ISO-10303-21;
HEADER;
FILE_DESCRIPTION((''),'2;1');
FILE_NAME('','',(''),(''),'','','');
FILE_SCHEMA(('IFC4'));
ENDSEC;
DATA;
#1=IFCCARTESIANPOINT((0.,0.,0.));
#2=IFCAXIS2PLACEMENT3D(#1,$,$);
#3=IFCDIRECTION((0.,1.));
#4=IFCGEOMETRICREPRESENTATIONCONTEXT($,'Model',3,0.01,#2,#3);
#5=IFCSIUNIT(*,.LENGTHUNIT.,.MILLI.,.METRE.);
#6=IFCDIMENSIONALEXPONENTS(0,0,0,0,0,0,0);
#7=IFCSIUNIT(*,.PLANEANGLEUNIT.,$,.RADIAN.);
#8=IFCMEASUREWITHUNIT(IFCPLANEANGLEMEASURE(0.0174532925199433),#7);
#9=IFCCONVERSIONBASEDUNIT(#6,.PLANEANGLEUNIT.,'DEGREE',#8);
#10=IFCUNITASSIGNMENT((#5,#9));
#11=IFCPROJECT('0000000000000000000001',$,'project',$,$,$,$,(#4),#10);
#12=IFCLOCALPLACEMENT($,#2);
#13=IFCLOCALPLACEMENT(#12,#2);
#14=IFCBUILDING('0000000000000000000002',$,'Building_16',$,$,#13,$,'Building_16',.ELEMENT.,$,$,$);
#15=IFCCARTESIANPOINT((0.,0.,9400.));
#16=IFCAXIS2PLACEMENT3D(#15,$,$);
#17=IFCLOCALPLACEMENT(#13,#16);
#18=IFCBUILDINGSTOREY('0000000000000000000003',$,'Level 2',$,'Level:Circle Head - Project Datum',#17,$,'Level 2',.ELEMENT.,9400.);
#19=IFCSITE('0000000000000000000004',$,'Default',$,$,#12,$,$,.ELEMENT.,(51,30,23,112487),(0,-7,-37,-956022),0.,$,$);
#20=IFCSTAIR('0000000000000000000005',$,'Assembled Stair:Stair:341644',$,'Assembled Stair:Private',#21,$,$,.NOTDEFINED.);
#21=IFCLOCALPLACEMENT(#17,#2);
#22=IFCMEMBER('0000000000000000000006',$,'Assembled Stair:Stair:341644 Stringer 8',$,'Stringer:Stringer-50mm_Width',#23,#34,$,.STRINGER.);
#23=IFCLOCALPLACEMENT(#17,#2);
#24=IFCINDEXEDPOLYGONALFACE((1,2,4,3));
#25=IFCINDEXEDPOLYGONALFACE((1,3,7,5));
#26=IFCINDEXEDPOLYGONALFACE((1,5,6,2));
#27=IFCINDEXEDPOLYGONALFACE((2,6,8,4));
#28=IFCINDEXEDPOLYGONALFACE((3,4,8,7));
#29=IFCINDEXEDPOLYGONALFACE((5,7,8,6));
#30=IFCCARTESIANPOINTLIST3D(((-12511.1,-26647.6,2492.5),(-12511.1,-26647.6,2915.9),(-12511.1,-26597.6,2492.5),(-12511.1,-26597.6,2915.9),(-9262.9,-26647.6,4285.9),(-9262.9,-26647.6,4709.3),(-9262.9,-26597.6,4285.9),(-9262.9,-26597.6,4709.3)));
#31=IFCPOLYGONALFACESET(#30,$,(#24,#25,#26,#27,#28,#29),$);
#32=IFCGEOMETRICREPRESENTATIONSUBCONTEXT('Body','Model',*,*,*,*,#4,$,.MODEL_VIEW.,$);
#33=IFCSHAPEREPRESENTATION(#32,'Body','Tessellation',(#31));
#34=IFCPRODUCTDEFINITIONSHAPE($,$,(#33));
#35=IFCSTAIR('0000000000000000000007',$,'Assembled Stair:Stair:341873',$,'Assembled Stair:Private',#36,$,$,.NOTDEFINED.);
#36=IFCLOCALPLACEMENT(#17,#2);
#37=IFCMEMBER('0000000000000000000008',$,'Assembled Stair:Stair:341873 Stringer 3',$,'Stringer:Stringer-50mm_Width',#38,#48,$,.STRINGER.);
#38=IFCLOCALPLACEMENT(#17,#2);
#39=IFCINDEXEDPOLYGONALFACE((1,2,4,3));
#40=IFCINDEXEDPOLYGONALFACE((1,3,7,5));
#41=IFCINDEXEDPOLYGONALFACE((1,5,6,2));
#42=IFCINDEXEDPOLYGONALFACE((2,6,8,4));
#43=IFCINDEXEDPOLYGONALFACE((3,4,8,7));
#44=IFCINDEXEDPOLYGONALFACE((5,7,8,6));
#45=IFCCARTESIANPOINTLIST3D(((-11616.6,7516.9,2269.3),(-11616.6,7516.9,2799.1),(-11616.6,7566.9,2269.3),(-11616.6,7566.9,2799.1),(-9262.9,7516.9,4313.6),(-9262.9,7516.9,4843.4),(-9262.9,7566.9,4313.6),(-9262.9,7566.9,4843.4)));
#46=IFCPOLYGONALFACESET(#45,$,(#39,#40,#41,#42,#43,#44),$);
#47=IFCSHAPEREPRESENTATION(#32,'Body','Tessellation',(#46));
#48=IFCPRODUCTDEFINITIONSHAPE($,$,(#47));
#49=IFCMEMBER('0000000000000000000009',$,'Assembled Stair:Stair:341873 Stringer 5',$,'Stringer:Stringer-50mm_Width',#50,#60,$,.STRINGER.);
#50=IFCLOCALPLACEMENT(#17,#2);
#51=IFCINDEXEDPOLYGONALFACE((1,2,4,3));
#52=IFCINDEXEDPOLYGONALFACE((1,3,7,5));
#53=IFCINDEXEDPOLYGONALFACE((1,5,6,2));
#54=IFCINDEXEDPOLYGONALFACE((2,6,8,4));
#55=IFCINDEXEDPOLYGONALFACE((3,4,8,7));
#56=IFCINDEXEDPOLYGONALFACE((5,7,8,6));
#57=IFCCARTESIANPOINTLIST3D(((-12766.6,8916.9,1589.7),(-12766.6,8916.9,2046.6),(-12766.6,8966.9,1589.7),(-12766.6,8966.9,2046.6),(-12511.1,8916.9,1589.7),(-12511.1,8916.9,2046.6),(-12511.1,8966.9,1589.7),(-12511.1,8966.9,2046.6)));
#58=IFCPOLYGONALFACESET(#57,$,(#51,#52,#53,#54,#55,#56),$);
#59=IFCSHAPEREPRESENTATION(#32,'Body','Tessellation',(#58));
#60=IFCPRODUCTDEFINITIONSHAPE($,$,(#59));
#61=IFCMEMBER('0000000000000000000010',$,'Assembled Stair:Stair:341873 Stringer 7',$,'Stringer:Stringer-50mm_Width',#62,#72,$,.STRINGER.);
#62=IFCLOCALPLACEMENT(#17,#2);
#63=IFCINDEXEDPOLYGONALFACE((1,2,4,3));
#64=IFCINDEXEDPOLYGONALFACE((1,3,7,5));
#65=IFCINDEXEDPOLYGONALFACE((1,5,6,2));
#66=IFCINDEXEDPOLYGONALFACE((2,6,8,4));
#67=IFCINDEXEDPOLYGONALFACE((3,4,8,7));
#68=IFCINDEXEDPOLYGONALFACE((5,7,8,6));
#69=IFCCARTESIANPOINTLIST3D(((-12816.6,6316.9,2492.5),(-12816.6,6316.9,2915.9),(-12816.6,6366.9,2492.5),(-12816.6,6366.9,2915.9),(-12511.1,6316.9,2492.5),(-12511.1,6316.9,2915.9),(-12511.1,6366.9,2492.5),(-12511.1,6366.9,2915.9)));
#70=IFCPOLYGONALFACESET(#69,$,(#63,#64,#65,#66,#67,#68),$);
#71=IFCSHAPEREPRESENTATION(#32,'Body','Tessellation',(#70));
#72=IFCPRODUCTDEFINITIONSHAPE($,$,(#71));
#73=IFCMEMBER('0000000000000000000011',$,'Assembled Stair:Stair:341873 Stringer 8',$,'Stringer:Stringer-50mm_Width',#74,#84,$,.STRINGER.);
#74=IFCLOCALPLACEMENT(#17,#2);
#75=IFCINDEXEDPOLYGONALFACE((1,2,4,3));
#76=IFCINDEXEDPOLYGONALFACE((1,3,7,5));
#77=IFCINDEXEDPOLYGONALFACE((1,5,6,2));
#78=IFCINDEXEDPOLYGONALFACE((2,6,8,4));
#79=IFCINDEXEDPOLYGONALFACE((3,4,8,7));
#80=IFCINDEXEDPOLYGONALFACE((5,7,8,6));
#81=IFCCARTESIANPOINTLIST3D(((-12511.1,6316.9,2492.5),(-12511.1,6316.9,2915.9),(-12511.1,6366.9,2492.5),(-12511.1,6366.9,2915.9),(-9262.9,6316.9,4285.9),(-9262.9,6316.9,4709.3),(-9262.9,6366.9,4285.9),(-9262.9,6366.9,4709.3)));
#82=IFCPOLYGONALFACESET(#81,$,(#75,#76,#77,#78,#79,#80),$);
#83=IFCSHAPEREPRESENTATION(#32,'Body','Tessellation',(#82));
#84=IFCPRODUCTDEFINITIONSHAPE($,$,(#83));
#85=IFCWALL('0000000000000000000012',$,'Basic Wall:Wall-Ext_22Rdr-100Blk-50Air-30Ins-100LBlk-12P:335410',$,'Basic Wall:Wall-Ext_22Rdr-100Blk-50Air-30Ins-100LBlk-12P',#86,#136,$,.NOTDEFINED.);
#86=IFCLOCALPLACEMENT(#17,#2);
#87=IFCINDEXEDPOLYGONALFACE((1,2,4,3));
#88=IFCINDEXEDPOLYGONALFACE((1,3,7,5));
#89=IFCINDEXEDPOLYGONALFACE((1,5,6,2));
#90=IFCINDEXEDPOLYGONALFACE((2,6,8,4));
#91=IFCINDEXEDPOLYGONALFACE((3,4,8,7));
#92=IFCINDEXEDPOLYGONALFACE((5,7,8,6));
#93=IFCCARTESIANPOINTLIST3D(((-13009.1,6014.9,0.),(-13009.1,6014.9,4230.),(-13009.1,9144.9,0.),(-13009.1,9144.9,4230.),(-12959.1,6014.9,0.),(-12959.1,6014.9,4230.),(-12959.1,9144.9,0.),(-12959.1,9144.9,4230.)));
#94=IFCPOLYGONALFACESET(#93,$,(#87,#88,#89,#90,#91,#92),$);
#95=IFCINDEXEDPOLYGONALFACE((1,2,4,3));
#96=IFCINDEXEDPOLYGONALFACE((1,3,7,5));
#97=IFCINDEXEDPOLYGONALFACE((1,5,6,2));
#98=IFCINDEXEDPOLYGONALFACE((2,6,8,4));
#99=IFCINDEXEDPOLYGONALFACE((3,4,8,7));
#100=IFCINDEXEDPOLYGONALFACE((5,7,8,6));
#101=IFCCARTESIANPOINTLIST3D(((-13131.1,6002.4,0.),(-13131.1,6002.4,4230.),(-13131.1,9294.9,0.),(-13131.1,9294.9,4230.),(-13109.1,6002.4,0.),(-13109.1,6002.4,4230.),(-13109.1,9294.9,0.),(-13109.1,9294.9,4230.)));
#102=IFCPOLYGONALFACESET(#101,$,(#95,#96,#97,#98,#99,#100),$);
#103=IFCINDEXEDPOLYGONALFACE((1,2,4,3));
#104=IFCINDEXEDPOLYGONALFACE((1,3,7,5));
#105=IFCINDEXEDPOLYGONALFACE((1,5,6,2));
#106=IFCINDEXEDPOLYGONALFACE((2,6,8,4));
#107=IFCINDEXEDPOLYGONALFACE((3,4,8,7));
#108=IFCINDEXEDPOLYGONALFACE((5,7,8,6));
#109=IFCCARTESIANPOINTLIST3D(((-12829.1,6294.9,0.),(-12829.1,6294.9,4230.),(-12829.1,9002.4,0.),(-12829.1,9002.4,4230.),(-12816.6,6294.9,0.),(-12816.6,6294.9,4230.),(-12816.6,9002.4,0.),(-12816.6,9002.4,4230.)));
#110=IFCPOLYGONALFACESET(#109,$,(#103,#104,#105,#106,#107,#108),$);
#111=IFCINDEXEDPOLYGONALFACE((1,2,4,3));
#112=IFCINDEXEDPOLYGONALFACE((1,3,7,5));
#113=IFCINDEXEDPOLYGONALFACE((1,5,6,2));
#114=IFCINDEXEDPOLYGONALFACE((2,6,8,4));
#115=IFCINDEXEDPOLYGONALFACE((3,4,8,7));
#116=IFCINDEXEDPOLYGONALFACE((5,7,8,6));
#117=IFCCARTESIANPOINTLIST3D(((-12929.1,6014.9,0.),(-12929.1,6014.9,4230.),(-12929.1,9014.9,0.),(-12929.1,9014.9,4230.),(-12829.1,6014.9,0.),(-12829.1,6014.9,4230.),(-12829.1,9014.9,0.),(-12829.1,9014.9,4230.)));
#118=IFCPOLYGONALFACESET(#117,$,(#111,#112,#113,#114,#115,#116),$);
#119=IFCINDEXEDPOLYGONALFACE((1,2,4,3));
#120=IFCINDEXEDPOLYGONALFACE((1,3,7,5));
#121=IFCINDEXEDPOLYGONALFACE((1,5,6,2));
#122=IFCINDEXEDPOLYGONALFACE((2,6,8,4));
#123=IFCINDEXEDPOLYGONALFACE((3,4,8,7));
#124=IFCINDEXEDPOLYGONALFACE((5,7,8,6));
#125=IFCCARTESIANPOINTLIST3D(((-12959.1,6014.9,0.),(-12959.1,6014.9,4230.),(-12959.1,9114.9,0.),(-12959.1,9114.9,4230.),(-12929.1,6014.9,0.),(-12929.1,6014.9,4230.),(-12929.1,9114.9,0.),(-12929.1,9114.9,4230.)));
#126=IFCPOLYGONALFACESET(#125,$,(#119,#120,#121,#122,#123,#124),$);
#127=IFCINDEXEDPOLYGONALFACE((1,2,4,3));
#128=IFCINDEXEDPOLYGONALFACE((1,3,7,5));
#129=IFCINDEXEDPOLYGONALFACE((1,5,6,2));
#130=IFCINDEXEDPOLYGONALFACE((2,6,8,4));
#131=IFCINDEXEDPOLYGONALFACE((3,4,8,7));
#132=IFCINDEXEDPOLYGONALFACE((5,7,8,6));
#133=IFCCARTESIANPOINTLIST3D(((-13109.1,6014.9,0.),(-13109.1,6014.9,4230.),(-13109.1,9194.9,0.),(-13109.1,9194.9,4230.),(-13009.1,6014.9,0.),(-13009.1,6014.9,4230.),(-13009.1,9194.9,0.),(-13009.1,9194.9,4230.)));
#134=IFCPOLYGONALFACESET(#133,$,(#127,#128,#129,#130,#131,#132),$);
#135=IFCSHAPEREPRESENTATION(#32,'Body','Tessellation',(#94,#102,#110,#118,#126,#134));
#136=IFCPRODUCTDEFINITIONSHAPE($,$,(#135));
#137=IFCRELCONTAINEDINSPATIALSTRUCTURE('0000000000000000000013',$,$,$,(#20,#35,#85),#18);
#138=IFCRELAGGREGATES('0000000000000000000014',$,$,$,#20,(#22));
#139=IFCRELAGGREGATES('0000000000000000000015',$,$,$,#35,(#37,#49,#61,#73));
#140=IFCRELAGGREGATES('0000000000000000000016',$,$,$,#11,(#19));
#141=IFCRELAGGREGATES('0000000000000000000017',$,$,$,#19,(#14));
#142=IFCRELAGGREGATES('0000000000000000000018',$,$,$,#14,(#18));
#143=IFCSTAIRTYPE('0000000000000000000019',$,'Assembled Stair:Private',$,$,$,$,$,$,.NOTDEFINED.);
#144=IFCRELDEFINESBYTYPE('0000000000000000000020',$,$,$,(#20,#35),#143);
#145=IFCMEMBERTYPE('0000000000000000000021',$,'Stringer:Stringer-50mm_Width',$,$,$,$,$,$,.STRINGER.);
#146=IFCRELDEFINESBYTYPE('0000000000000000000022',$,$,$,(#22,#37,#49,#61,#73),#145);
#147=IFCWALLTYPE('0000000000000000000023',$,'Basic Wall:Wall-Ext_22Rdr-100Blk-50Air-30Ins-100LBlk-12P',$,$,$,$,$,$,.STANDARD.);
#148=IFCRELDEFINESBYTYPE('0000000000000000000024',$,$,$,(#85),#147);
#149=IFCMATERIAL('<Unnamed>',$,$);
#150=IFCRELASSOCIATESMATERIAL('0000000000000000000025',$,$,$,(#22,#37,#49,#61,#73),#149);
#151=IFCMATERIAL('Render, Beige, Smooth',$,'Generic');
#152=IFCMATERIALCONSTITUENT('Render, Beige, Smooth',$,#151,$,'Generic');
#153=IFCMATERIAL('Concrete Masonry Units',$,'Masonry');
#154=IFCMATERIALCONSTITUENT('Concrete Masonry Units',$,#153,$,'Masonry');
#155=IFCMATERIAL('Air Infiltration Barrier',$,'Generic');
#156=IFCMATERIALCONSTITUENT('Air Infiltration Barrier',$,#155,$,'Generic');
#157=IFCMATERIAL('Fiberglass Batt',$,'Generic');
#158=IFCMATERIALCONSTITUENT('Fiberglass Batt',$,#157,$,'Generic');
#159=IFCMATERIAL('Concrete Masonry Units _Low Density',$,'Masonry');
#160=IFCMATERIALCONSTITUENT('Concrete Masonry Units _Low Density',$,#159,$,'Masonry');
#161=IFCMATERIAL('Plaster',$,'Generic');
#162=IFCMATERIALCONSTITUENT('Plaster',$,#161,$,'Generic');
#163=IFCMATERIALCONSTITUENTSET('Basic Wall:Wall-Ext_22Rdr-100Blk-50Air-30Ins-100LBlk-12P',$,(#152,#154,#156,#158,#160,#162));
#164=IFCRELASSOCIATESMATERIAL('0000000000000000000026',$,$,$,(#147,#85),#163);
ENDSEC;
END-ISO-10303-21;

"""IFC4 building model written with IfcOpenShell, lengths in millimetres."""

from ifc_helpers import new_model, entity, si_unit, converted_unit, direction, frame, origin, place, context, subcontext, project, spatial, indexed_curve, outline, extrude, material, constituent, constituent_set, type_object, element, aggregate, save


model = new_model("IFC4")

# Units and contexts
model_context = context("Model", 3, precision=0.01, world=origin(), true_north=direction((0.0, 1.0)))
body_context = subcontext(model_context, "Body", "Model", "MODEL_VIEW")
ifc_project = project(units=[si_unit("LENGTHUNIT", "METRE", prefix="MILLI"), converted_unit("PLANEANGLEUNIT", "DEGREE", entity("IfcPlaneAngleMeasure", 0.0174532925199433), si_unit("PLANEANGLEUNIT", "RADIAN"), dimensions=[0, 0, 0, 0, 0, 0, 0])], contexts=[model_context])

# Site, building, storey
site_placement = place(None, origin())
site = spatial("IfcSite", under=ifc_project, at=site_placement, Name="Default", CompositionType="ELEMENT", RefLatitude=(51, 30, 23, 112487), RefLongitude=(0, -7, -37, -956022), RefElevation=0.0)
building_placement = place(site_placement, origin())
building = spatial("IfcBuilding", under=site, at=building_placement, Name="Building_16", LongName="Building_16", CompositionType="ELEMENT")
storey_placement = place(building_placement, frame((0.0, 0.0, 9400.0)))
storey = spatial("IfcBuildingStorey", under=building, at=storey_placement, Name="Level 2", ObjectType="Level:Circle Head - Project Datum", LongName="Level 2", CompositionType="ELEMENT", Elevation=9400.0)

# Stair, member
stair_type = type_object("IfcStairType", Name="Assembled Stair:Private", PredefinedType="NOTDEFINED")
stair_1_placement = place(storey_placement, origin())
stair_1 = element("IfcStair", 1, at=stair_1_placement, inside=storey, type_object=stair_type, Name="Assembled Stair:Stair:341644", ObjectType="Assembled Stair:Private", PredefinedType="NOTDEFINED")
ifc_material_1 = material(Name="<Unnamed>")
member_type = type_object("IfcMemberType", Name="Stringer:Stringer-50mm_Width", PredefinedType="STRINGER")
member_1_placement = place(stair_1_placement, origin())
member_1 = element("IfcMember", 2, at=member_1_placement, type_object=member_type, material=ifc_material_1, Name="Assembled Stair:Stair:341644 Stringer 8", ObjectType="Stringer:Stringer-50mm_Width", PredefinedType="STRINGER", context=body_context, shape_type="SweptSolid", body=[
    extrude(outline(indexed_curve([(-1752.9, -185.3), (1957.5, -185.3), (1752.9, 185.3), (-1957.5, 185.3), (-1752.9, -185.3)], self_intersect=False)), frame((-10887.0, -26647.6, 3600.9), z_axis=(0.0, 1.0, 0.0), x_axis=(0.875434, 0.0, 0.483338)), (0.0, 0.0, 1.0), 50.0),
])
aggregate(stair_1, [member_1])

# Stair, members
stair_2_placement = place(storey_placement, origin())
stair_2 = element("IfcStair", 3, at=stair_2_placement, inside=storey, type_object=stair_type, Name="Assembled Stair:Stair:341873", ObjectType="Assembled Stair:Private", PredefinedType="NOTDEFINED")
member_2_placement = place(stair_2_placement, origin())
member_2 = element("IfcMember", 4, at=member_2_placement, type_object=member_type, material=ifc_material_1, Name="Assembled Stair:Stair:341873 Stringer 3", ObjectType="Stringer:Stringer-50mm_Width", PredefinedType="STRINGER", context=body_context, shape_type="SweptSolid", body=[
    extrude(outline(indexed_curve([(-1385.1, -200.0), (1732.5, -200.0), (1385.1, 200.0), (-1732.5, 200.0), (-1385.1, -200.0)], self_intersect=False)), frame((-10439.8, 7516.9, 3556.4), z_axis=(0.0, 1.0, 0.0), x_axis=(0.754989, 0.0, 0.655738)), (0.0, 0.0, 1.0), 50.0),
])
member_3_placement = place(stair_2_placement, origin())
member_3 = element("IfcMember", 5, at=member_3_placement, type_object=member_type, material=ifc_material_1, Name="Assembled Stair:Stair:341873 Stringer 5", ObjectType="Stringer:Stringer-50mm_Width", PredefinedType="STRINGER", context=body_context, shape_type="SweptSolid", body=[
    extrude(outline(indexed_curve([(-127.7, -25.0), (127.7, -25.0), (127.7, 25.0), (-127.7, 25.0), (-127.7, -25.0)], self_intersect=False)), frame((-12638.9, 8941.9, 1589.7), z_axis=(0.0, 0.0, 1.0), x_axis=(-1.0, 0.0, 0.0)), (0.0, 0.0, 1.0), 456.9),
])
member_4_placement = place(stair_2_placement, origin())
member_4 = element("IfcMember", 6, at=member_4_placement, type_object=member_type, material=ifc_material_1, Name="Assembled Stair:Stair:341873 Stringer 7", ObjectType="Stringer:Stringer-50mm_Width", PredefinedType="STRINGER", context=body_context, shape_type="SweptSolid", body=[
    extrude(outline(indexed_curve([(-152.7, -25.0), (152.7, -25.0), (152.7, 25.0), (-152.7, 25.0), (-152.7, -25.0)], self_intersect=False)), frame((-12663.9, 6341.9, 2492.5)), (0.0, 0.0, 1.0), 423.4),
])
member_5_placement = place(stair_2_placement, origin())
member_5 = element("IfcMember", 7, at=member_5_placement, type_object=member_type, material=ifc_material_1, Name="Assembled Stair:Stair:341873 Stringer 8", ObjectType="Stringer:Stringer-50mm_Width", PredefinedType="STRINGER", context=body_context, shape_type="SweptSolid", body=[
    extrude(outline(indexed_curve([(-1752.9, -185.3), (1957.5, -185.3), (1752.9, 185.3), (-1957.5, 185.3), (-1752.9, -185.3)], self_intersect=False)), frame((-10887.0, 6316.9, 3600.9), z_axis=(0.0, 1.0, 0.0), x_axis=(0.875434, 0.0, 0.483338)), (0.0, 0.0, 1.0), 50.0),
])
aggregate(stair_2, [member_2, member_3, member_4, member_5])

# Shared definitions
ifc_material_2 = material(Name="Render, Beige, Smooth", Category="Generic")
ifc_constituent_1 = constituent(ifc_material_2, Name="Render, Beige, Smooth", Category="Generic")
ifc_material_3 = material(Name="Concrete Masonry Units", Category="Masonry")
ifc_constituent_2 = constituent(ifc_material_3, Name="Concrete Masonry Units", Category="Masonry")
ifc_material_4 = material(Name="Air Infiltration Barrier", Category="Generic")
ifc_constituent_3 = constituent(ifc_material_4, Name="Air Infiltration Barrier", Category="Generic")
ifc_material_5 = material(Name="Fiberglass Batt", Category="Generic")
ifc_constituent_4 = constituent(ifc_material_5, Name="Fiberglass Batt", Category="Generic")
ifc_material_6 = material(Name="Concrete Masonry Units _Low Density", Category="Masonry")
ifc_constituent_5 = constituent(ifc_material_6, Name="Concrete Masonry Units _Low Density", Category="Masonry")
ifc_material_7 = material(Name="Plaster", Category="Generic")
ifc_constituent_6 = constituent(ifc_material_7, Name="Plaster", Category="Generic")
ifc_constituent_set_1 = constituent_set(constituents=[ifc_constituent_1, ifc_constituent_2, ifc_constituent_3, ifc_constituent_4, ifc_constituent_5, ifc_constituent_6], Name="Basic Wall:Wall-Ext_22Rdr-100Blk-50Air-30Ins-100LBlk-12P")
wall_type_1 = type_object("IfcWallType", Name="Basic Wall:Wall-Ext_22Rdr-100Blk-50Air-30Ins-100LBlk-12P", PredefinedType="STANDARD", material=ifc_constituent_set_1)

# Wall
wall_1_placement = place(storey_placement, frame((-12973.9, 6002.4, 0.0), z_axis=(0.0, 0.0, 1.0), x_axis=(0.0, 1.0, 0.0)))
element("IfcWall", 8, at=wall_1_placement, inside=storey, type_object=wall_type_1, material=ifc_constituent_set_1, Name="Basic Wall:Wall-Ext_22Rdr-100Blk-50Air-30Ins-100LBlk-12P:335410", ObjectType="Basic Wall:Wall-Ext_22Rdr-100Blk-50Air-30Ins-100LBlk-12P", PredefinedType="NOTDEFINED", context=body_context, shape_type="SweptSolid", body=[
    extrude(outline(indexed_curve([(-2115.0, -1565.0), (2115.0, -1565.0), (2115.0, 1565.0), (-2115.0, 1565.0), (-2115.0, -1565.0)], self_intersect=False)), frame((1577.5, 35.3, 2115.0), z_axis=(0.0, -1.0, 0.0), x_axis=(0.0, 0.0, 1.0)), (0.0, 0.0, 1.0), 50.0),
    extrude(outline(indexed_curve([(-1646.2, -2115.0), (1646.3, -2115.0), (1646.3, 2115.0), (-1646.2, 2115.0), (-1646.2, -2115.0)], self_intersect=False)), frame((1646.2, 157.3, 2115.0), z_axis=(0.0, -1.0, 0.0), x_axis=(1.0, 0.0, 0.0)), (0.0, 0.0, 1.0), 22.0),
    extrude(outline(indexed_curve([(-2115.0, -1353.8), (2115.0, -1353.8), (2115.0, 1353.8), (-2115.0, 1353.8), (-2115.0, -1353.8)], self_intersect=False)), frame((1646.2, -144.8, 2115.0), z_axis=(0.0, -1.0, 0.0), x_axis=(0.0, 0.0, 1.0)), (0.0, 0.0, 1.0), 12.5),
    extrude(outline(indexed_curve([(-2115.0, -1500.0), (2115.0, -1500.0), (2115.0, 1500.0), (-2115.0, 1500.0), (-2115.0, -1500.0)], self_intersect=False)), frame((1512.5, -44.8, 2115.0), z_axis=(0.0, -1.0, 0.0), x_axis=(0.0, 0.0, 1.0)), (0.0, 0.0, 1.0), 100.0),
    extrude(outline(indexed_curve([(-2115.0, -1550.0), (2115.0, -1550.0), (2115.0, 1550.0), (-2115.0, 1550.0), (-2115.0, -1550.0)], self_intersect=False)), frame((1562.5, -14.8, 2115.0), z_axis=(0.0, -1.0, 0.0), x_axis=(0.0, 0.0, 1.0)), (0.0, 0.0, 1.0), 30.0),
    extrude(outline(indexed_curve([(-2115.0, -1590.0), (2115.0, -1590.0), (2115.0, 1590.0), (-2115.0, 1590.0), (-2115.0, -1590.0)], self_intersect=False)), frame((1602.5, 135.2, 2115.0), z_axis=(0.0, -1.0, 0.0), x_axis=(0.0, 0.0, 1.0)), (0.0, 0.0, 1.0), 100.0),
])

save(model, "model.ifc")
